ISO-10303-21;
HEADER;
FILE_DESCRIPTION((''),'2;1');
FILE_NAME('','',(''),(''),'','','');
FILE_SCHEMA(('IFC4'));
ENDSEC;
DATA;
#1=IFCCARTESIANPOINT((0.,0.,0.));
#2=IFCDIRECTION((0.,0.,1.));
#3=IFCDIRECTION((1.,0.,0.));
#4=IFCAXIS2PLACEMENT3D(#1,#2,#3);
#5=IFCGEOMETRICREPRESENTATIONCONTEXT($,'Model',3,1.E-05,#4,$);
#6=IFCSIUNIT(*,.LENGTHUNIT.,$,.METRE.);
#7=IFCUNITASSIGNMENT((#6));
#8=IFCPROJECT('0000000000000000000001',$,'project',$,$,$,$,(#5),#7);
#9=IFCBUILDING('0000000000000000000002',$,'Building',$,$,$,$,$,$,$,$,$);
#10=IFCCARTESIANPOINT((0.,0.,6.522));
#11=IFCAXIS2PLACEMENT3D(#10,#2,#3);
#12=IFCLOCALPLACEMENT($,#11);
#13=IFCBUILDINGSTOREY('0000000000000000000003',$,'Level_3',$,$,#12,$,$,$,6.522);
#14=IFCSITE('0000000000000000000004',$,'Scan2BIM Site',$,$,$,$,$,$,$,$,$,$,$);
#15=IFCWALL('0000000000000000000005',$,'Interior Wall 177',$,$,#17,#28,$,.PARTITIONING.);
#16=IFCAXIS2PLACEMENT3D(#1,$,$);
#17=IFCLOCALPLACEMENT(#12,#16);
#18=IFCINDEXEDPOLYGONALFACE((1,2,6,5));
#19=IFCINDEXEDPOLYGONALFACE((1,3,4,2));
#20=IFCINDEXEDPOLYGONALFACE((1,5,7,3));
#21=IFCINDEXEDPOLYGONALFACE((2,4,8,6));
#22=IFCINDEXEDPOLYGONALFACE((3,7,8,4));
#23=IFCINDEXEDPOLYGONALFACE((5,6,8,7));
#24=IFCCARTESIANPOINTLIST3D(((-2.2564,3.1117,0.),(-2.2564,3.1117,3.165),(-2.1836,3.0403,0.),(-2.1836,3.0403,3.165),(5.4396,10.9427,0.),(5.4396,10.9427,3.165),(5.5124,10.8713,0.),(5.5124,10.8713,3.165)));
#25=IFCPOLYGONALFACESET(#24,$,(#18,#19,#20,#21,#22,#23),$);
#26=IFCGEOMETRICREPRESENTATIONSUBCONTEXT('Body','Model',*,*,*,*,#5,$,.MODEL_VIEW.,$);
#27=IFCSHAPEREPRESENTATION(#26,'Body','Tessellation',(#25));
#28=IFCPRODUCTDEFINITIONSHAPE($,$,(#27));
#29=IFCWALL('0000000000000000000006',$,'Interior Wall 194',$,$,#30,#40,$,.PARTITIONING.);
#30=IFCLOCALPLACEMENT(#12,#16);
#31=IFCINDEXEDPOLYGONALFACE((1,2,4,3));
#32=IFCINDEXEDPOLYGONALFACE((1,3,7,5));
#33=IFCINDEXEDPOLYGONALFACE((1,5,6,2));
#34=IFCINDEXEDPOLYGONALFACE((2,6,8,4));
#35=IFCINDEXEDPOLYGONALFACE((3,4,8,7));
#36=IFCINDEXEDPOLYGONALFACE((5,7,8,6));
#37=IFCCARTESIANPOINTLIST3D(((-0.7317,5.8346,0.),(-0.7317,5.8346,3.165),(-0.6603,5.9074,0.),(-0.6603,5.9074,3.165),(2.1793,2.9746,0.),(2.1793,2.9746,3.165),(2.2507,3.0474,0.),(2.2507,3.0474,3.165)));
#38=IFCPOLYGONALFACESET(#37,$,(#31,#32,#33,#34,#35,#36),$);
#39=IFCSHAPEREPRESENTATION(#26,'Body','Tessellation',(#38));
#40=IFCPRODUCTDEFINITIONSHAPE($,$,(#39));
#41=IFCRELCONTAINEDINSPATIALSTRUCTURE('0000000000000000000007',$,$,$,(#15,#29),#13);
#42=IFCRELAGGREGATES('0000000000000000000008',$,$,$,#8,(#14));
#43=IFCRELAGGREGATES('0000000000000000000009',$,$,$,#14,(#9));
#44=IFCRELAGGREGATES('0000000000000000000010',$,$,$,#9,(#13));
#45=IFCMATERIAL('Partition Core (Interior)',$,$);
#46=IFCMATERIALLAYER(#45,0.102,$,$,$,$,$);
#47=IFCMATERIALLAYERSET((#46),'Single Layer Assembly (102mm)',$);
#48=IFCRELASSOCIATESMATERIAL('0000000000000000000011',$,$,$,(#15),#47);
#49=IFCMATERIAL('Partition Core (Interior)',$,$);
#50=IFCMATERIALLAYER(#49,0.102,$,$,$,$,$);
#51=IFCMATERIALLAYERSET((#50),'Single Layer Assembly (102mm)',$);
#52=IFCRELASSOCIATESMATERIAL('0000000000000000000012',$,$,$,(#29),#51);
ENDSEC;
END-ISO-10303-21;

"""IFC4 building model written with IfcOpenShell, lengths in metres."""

from ifc_helpers import new_model, si_unit, frame, origin, origin_with_axes, place, context, subcontext, project, spatial, rectangle, extrude, material, layer, layer_set, element, save


model = new_model("IFC4")

# Units and contexts
model_context = context("Model", 3, precision=1e-05, world=origin_with_axes())
body_context = subcontext(model_context, "Body", "Model", "MODEL_VIEW")
ifc_project = project(units=[si_unit("LENGTHUNIT", "METRE")], contexts=[model_context])

# Site, building, storey
site = spatial("IfcSite", under=ifc_project, Name="Scan2BIM Site")
building = spatial("IfcBuilding", under=site, Name="Building")
storey_placement = place(None, frame((0.0, 0.0, 6.522), z_axis=(0.0, 0.0, 1.0), x_axis=(1.0, 0.0, 0.0)))
storey = spatial("IfcBuildingStorey", under=building, at=storey_placement, Name="Level_3", Elevation=6.522)

# Walls
ifc_material_1 = material(Name="Partition Core (Interior)")
ifc_layer_1 = layer(ifc_material_1, 0.102)
ifc_layer_set_1 = layer_set([ifc_layer_1], Name="Single Layer Assembly (102mm)")
wall_1_placement = place(storey_placement, frame((1.628, 6.9915, 0.0), z_axis=(0.0, 0.0, 1.0), x_axis=(-0.700932, -0.713228, 0.0)))
element("IfcWall", 1, at=wall_1_placement, inside=storey, material=ifc_layer_set_1, Name="Interior Wall 177", PredefinedType="PARTITIONING", context=body_context, shape_type="SweptSolid", body=[
    extrude(rectangle(XDim=10.9797, YDim=0.102), origin(), (0.0, 0.0, 1.0), 3.165),
])
ifc_material_2 = material(Name="Partition Core (Interior)")
ifc_layer_2 = layer(ifc_material_2, 0.102)
ifc_layer_set_2 = layer_set([ifc_layer_2], Name="Single Layer Assembly (102mm)")
wall_2_placement = place(storey_placement, frame((0.7595, 4.441, 0.0), z_axis=(0.0, 0.0, 1.0), x_axis=(-0.713328, 0.700831, 0.0)))
element("IfcWall", 2, at=wall_2_placement, inside=storey, material=ifc_layer_set_2, Name="Interior Wall 194", PredefinedType="PARTITIONING", context=body_context, shape_type="SweptSolid", body=[
    extrude(rectangle(XDim=4.0809, YDim=0.102), origin(), (0.0, 0.0, 1.0), 3.165),
])

save(model, "model.ifc")
